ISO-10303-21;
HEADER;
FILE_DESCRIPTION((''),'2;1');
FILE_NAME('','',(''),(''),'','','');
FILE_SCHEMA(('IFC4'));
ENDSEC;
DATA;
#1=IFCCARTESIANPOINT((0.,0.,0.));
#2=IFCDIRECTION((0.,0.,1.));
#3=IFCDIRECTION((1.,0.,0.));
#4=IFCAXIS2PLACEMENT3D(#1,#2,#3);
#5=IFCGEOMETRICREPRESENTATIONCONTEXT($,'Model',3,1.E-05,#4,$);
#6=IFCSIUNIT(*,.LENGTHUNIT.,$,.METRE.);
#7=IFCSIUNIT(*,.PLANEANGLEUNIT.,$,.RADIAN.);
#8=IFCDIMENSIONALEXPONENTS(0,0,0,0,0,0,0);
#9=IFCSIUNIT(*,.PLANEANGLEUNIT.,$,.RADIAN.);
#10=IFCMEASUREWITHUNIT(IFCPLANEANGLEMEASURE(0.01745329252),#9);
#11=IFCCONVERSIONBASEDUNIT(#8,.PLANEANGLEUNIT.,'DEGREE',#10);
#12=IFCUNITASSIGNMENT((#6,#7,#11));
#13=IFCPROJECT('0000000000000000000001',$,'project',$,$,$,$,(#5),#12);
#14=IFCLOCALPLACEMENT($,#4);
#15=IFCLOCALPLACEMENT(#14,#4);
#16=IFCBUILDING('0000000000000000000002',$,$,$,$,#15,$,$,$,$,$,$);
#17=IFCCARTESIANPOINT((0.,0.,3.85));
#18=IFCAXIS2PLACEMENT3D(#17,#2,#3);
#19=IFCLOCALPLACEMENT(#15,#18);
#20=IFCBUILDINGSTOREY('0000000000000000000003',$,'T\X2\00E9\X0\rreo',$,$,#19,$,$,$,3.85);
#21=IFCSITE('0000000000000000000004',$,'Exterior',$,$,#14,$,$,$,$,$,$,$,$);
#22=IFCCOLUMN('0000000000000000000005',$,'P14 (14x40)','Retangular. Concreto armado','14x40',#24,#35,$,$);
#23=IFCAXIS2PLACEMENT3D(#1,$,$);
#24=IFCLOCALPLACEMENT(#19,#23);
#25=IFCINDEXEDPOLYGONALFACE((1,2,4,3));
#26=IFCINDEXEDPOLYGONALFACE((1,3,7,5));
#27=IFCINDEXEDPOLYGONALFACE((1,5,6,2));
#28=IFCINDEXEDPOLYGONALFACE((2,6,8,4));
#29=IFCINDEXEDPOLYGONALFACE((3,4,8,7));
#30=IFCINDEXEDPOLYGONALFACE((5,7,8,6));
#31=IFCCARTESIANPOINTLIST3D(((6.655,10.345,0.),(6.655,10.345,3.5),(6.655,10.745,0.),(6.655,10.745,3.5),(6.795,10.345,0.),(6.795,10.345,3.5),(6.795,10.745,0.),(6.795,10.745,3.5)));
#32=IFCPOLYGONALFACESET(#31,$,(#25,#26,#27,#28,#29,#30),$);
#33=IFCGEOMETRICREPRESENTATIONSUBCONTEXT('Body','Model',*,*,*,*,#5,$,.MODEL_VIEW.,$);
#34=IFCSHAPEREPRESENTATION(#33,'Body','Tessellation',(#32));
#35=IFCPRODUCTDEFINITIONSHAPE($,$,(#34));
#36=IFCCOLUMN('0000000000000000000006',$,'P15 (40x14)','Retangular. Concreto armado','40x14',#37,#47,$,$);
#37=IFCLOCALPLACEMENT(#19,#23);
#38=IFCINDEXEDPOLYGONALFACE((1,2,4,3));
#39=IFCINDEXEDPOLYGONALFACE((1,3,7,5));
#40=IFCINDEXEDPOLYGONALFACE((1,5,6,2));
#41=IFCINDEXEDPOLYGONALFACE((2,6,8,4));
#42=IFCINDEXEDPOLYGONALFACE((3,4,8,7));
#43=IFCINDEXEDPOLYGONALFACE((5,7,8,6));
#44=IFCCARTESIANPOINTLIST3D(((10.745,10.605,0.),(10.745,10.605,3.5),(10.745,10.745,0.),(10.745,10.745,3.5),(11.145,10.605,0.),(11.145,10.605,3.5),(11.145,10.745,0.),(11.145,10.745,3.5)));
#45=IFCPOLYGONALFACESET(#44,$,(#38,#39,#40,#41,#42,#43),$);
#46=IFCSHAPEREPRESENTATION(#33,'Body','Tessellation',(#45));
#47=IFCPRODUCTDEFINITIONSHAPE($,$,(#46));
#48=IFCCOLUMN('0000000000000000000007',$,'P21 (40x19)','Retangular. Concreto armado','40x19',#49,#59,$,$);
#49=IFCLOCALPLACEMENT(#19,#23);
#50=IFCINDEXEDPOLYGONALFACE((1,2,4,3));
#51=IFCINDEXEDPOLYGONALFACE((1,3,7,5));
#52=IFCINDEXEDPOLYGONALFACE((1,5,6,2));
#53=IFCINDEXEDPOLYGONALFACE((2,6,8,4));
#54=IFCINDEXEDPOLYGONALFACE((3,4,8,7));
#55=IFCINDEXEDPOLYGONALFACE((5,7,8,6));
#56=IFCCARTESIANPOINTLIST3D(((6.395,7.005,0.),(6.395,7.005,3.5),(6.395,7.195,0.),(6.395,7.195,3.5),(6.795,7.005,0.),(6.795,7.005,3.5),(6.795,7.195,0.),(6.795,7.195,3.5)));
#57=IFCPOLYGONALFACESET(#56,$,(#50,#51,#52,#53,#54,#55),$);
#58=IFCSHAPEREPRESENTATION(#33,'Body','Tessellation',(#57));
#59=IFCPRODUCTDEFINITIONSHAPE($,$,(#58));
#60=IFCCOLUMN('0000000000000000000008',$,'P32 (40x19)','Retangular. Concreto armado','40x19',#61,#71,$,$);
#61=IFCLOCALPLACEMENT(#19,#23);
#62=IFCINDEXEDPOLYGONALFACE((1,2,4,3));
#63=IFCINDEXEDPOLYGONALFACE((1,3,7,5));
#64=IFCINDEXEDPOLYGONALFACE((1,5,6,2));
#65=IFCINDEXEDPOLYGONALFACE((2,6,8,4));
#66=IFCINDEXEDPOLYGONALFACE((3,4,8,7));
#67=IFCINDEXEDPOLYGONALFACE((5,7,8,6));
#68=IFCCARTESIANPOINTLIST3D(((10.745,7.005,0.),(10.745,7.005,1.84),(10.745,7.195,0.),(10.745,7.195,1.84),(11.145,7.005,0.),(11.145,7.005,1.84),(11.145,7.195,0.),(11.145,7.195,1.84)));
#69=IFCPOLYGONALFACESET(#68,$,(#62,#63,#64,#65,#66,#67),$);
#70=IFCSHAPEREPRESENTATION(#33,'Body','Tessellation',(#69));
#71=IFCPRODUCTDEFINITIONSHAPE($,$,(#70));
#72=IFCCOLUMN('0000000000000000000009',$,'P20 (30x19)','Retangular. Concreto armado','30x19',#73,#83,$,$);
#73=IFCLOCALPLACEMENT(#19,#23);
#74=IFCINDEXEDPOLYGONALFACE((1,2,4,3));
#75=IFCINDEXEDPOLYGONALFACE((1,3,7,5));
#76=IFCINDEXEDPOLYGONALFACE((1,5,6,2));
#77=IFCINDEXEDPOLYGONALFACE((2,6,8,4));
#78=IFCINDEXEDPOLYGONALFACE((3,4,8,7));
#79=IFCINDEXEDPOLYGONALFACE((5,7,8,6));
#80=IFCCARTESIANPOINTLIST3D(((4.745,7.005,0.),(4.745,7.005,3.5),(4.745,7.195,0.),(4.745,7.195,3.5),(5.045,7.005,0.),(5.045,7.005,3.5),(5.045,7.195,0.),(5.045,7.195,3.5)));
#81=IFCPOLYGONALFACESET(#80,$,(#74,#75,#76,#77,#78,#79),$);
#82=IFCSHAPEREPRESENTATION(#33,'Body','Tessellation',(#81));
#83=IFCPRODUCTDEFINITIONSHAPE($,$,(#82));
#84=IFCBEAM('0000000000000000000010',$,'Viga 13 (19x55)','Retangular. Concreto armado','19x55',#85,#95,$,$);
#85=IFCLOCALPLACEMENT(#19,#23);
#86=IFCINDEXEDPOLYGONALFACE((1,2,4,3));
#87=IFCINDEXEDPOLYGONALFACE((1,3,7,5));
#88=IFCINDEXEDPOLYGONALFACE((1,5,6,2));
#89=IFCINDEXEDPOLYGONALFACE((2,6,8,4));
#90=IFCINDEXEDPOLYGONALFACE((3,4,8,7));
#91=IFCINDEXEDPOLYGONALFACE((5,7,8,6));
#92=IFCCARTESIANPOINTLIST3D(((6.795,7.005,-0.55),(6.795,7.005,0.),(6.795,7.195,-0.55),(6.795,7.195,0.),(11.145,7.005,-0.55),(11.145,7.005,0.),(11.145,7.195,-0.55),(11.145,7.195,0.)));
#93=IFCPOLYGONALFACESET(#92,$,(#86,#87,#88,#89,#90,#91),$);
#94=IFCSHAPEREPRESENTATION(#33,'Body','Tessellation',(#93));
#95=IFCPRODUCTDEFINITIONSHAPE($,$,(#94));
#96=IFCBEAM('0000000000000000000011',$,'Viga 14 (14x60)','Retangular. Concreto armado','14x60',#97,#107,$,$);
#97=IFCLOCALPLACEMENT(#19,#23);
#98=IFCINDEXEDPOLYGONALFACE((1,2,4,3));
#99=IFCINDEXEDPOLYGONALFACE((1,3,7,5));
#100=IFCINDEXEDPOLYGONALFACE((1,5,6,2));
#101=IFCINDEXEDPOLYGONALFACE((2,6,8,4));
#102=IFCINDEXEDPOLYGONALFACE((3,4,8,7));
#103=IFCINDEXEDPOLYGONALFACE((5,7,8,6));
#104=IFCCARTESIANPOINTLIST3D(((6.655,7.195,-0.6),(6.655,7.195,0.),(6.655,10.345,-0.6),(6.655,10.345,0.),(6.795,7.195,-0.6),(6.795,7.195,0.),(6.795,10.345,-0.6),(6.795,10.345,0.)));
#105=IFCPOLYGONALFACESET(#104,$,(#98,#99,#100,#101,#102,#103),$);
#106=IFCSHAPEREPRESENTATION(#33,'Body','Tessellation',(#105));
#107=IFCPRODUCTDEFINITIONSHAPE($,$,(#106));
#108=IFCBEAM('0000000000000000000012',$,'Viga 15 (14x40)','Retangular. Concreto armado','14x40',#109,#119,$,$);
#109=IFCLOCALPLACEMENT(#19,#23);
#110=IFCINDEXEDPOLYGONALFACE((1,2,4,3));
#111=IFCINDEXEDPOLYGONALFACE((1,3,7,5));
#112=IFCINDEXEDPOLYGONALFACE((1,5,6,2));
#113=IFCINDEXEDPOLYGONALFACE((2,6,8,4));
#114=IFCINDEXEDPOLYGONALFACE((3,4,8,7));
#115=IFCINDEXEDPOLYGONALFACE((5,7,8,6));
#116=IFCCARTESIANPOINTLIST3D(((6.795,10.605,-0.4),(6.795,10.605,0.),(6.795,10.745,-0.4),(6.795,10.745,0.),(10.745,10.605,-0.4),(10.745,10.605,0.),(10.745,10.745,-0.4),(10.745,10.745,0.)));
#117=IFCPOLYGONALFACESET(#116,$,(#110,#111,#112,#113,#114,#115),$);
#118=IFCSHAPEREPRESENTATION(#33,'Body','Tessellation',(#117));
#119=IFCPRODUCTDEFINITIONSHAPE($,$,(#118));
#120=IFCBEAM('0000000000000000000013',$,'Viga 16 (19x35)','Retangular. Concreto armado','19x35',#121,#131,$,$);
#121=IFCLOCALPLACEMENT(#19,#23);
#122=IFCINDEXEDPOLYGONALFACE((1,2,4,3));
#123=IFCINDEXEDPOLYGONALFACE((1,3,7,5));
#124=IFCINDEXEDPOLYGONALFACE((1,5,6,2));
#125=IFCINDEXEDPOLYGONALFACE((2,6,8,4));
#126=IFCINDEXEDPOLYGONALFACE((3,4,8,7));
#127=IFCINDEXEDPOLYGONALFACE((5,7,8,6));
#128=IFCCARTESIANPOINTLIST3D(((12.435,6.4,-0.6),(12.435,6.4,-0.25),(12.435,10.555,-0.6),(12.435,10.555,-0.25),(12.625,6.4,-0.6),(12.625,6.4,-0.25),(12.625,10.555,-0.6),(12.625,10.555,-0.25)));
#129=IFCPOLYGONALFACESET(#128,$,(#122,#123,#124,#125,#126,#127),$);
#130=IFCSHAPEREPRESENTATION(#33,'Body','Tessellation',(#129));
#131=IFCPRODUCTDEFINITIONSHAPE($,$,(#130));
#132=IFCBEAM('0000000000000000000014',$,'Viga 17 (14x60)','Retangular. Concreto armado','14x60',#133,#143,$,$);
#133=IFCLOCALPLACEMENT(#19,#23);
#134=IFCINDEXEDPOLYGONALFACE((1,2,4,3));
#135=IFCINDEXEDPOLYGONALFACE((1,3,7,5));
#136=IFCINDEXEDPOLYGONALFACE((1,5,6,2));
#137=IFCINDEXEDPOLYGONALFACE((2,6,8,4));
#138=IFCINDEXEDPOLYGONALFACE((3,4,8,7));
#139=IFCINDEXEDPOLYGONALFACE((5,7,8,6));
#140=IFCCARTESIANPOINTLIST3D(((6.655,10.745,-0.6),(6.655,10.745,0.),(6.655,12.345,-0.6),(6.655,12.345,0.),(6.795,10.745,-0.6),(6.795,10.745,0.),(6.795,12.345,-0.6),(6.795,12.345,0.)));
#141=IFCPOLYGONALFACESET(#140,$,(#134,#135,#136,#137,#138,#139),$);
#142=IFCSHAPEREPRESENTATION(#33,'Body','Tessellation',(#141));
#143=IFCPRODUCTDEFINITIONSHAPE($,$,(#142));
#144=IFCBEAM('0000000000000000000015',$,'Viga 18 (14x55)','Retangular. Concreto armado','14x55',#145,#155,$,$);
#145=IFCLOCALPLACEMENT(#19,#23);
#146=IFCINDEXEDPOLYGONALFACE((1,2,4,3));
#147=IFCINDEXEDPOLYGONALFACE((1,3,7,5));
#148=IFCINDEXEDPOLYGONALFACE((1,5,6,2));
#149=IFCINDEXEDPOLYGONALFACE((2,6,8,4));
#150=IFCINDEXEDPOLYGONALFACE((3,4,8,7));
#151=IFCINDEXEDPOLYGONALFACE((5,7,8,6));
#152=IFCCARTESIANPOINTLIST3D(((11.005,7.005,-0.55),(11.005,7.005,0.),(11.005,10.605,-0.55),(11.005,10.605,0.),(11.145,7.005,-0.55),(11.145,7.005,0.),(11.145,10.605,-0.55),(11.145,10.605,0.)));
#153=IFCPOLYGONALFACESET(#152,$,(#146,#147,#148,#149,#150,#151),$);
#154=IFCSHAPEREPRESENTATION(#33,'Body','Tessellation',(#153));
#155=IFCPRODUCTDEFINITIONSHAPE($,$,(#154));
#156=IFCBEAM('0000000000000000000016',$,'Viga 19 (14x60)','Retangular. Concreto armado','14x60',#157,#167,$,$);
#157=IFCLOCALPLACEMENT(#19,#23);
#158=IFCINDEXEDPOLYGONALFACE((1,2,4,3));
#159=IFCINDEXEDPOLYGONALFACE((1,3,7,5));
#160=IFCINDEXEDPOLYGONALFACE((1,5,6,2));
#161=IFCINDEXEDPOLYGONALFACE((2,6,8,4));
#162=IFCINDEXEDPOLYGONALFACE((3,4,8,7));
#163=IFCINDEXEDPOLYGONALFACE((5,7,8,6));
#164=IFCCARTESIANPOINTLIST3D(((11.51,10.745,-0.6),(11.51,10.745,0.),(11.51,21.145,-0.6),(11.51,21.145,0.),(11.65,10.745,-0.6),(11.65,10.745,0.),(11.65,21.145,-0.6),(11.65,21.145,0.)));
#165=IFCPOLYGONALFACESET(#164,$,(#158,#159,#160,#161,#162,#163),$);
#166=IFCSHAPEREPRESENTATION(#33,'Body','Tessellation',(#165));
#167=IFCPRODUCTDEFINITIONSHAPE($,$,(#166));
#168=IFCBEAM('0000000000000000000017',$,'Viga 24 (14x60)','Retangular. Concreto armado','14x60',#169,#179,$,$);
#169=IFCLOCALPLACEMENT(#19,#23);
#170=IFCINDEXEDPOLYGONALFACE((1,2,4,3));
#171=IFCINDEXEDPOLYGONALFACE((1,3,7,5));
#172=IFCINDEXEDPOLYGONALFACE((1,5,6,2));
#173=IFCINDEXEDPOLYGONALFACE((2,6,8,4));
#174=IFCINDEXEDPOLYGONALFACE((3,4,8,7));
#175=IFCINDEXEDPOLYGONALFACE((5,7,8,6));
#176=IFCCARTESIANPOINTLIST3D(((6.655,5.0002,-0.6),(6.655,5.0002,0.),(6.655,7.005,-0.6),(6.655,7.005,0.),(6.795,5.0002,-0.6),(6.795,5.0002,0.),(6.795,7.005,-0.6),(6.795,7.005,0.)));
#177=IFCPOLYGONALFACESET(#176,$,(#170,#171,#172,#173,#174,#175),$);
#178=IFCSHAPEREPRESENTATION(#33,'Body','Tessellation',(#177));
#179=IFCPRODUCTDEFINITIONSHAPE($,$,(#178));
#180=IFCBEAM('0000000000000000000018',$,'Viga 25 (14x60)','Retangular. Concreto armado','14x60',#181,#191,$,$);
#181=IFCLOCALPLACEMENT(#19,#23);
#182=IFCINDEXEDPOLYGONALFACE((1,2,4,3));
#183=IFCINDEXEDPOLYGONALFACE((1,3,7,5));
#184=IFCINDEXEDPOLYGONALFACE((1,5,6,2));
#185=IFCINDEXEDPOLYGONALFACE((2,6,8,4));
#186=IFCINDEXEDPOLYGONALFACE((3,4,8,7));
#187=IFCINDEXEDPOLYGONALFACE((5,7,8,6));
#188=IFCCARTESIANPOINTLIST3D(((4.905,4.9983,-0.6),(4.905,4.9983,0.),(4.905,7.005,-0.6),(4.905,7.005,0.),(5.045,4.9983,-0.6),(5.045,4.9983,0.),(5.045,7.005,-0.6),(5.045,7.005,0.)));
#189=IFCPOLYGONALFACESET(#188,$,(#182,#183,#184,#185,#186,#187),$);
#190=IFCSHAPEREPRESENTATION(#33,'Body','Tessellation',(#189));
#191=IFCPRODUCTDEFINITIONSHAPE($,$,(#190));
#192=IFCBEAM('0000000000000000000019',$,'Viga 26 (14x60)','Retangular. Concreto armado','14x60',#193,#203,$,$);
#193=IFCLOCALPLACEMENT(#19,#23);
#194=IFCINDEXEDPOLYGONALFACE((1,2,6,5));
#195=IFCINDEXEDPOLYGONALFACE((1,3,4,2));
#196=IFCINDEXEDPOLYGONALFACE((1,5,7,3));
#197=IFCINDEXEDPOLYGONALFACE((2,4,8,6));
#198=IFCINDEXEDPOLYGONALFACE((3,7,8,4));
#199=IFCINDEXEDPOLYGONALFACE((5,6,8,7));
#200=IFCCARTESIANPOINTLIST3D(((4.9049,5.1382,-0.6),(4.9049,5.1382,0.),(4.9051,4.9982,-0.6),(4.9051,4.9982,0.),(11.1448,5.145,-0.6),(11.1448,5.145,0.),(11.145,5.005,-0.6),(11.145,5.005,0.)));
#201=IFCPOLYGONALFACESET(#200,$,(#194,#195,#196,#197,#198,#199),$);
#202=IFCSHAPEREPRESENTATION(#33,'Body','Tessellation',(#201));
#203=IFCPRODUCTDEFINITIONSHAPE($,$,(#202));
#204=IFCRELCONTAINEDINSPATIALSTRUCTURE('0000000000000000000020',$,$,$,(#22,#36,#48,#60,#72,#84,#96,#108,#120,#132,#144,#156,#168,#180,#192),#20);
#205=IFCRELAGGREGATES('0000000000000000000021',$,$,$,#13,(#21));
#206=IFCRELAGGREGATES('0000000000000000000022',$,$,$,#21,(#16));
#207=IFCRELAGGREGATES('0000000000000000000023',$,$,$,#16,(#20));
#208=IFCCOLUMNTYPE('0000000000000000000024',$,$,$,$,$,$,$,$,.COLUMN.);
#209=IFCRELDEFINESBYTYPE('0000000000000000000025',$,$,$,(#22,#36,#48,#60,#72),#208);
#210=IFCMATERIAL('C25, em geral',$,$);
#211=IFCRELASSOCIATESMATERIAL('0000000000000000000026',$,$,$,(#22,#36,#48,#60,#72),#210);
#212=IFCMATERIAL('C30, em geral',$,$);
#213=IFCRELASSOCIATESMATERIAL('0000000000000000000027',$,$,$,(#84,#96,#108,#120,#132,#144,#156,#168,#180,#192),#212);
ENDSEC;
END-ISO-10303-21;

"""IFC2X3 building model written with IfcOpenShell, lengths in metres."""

from ifc_helpers import new_model, entity, si_unit, converted_unit, frame, frame_2d, origin_with_axes, place, context, subcontext, project, spatial, rectangle, extrude, material, type_object, element, save


model = new_model("IFC2X3")

# Units and contexts
model_context = context("Model", 3, precision=1e-05, world=origin_with_axes())
body_context = subcontext(model_context, "Body", "Model", "MODEL_VIEW")
ifc_project = project(units=[si_unit("LENGTHUNIT", "METRE"), si_unit("PLANEANGLEUNIT", "RADIAN"), converted_unit("PLANEANGLEUNIT", "DEGREE", entity("IfcPlaneAngleMeasure", 0.01745329252), si_unit("PLANEANGLEUNIT", "RADIAN"), dimensions=[0, 0, 0, 0, 0, 0, 0])], contexts=[model_context])

# Site, building, storey
site_placement = place(None, origin_with_axes())
site = spatial("IfcSite", under=ifc_project, at=site_placement, Name="Exterior")
building_placement = place(site_placement, origin_with_axes())
building = spatial("IfcBuilding", under=site, at=building_placement)
storey_placement = place(building_placement, frame((0.0, 0.0, 3.85), z_axis=(0.0, 0.0, 1.0), x_axis=(1.0, 0.0, 0.0)))
storey = spatial("IfcBuildingStorey", under=building, at=storey_placement, Name="Térreo", Elevation=3.85)

# Columns
ifc_material_1 = material(Name="C25, em geral")
column_type = type_object("IfcColumnType", PredefinedType="COLUMN")
column_1_placement = place(storey_placement, frame((6.655, 10.745, 0.0), z_axis=(0.0, 0.0, 1.0), x_axis=(1.0, 0.0, 0.0)))
element("IfcColumn", 1, at=column_1_placement, inside=storey, type_object=column_type, material=ifc_material_1, Name="P14 (14x40)", Description="Retangular. Concreto armado", ObjectType="14x40", context=body_context, shape_type="SweptSolid", body=[
    extrude(rectangle(XDim=0.14, YDim=0.4, at=frame_2d((0.07, -0.2), x_axis=(1.0, 0.0))), origin_with_axes(), (0.0, 0.0, 1.0), 3.5),
])
column_2_placement = place(storey_placement, frame((11.145, 10.605, 0.0), z_axis=(0.0, 0.0, 1.0), x_axis=(1.0, 0.0, 0.0)))
element("IfcColumn", 2, at=column_2_placement, inside=storey, type_object=column_type, material=ifc_material_1, Name="P15 (40x14)", Description="Retangular. Concreto armado", ObjectType="40x14", context=body_context, shape_type="SweptSolid", body=[
    extrude(rectangle(XDim=0.4, YDim=0.14, at=frame_2d((-0.2, 0.07), x_axis=(1.0, 0.0))), origin_with_axes(), (0.0, 0.0, 1.0), 3.5),
])
column_3_placement = place(storey_placement, frame((6.795, 7.005, 0.0), z_axis=(0.0, 0.0, 1.0), x_axis=(1.0, 0.0, 0.0)))
element("IfcColumn", 3, at=column_3_placement, inside=storey, type_object=column_type, material=ifc_material_1, Name="P21 (40x19)", Description="Retangular. Concreto armado", ObjectType="40x19", context=body_context, shape_type="SweptSolid", body=[
    extrude(rectangle(XDim=0.4, YDim=0.19, at=frame_2d((-0.2, 0.095), x_axis=(1.0, 0.0))), origin_with_axes(), (0.0, 0.0, 1.0), 3.5),
])
column_4_placement = place(storey_placement, frame((11.145, 7.005, 0.0), z_axis=(0.0, 0.0, 1.0), x_axis=(1.0, 0.0, 0.0)))
element("IfcColumn", 4, at=column_4_placement, inside=storey, type_object=column_type, material=ifc_material_1, Name="P32 (40x19)", Description="Retangular. Concreto armado", ObjectType="40x19", context=body_context, shape_type="SweptSolid", body=[
    extrude(rectangle(XDim=0.4, YDim=0.19, at=frame_2d((-0.2, 0.095), x_axis=(1.0, 0.0))), origin_with_axes(), (0.0, 0.0, 1.0), 1.84),
])
column_5_placement = place(storey_placement, frame((5.045, 7.005, 0.0), z_axis=(0.0, 0.0, 1.0), x_axis=(1.0, 0.0, 0.0)))
element("IfcColumn", 5, at=column_5_placement, inside=storey, type_object=column_type, material=ifc_material_1, Name="P20 (30x19)", Description="Retangular. Concreto armado", ObjectType="30x19", context=body_context, shape_type="SweptSolid", body=[
    extrude(rectangle(XDim=0.3, YDim=0.19, at=frame_2d((-0.15, 0.095), x_axis=(1.0, 0.0))), origin_with_axes(), (0.0, 0.0, 1.0), 3.5),
])

# Beams
ifc_material_2 = material(Name="C30, em geral")
beam_1_placement = place(storey_placement, frame((6.795, 7.1, 0.0), z_axis=(1.0, 0.0, 0.0), x_axis=(0.0, 1.0, 0.0)))
element("IfcBeam", 6, at=beam_1_placement, inside=storey, material=ifc_material_2, Name="Viga 13 (19x55)", Description="Retangular. Concreto armado", ObjectType="19x55", context=body_context, shape_type="SweptSolid", body=[
    extrude(rectangle(XDim=0.19, YDim=0.55, at=frame_2d((0.0, -0.275), x_axis=(1.0, 0.0))), origin_with_axes(), (0.0, 0.0, 1.0), 4.35),
])
beam_2_placement = place(storey_placement, frame((6.725, 10.345, 0.0), z_axis=(0.0, -1.0, 0.0), x_axis=(1.0, 0.0, 0.0)))
element("IfcBeam", 7, at=beam_2_placement, inside=storey, material=ifc_material_2, Name="Viga 14 (14x60)", Description="Retangular. Concreto armado", ObjectType="14x60", context=body_context, shape_type="SweptSolid", body=[
    extrude(rectangle(XDim=0.14, YDim=0.6, at=frame_2d((0.0, -0.3), x_axis=(1.0, 0.0))), origin_with_axes(), (0.0, 0.0, 1.0), 3.15),
])
beam_3_placement = place(storey_placement, frame((6.795, 10.675, 0.0), z_axis=(1.0, 0.0, 0.0), x_axis=(0.0, 1.0, 0.0)))
element("IfcBeam", 8, at=beam_3_placement, inside=storey, material=ifc_material_2, Name="Viga 15 (14x40)", Description="Retangular. Concreto armado", ObjectType="14x40", context=body_context, shape_type="SweptSolid", body=[
    extrude(rectangle(XDim=0.14, YDim=0.4, at=frame_2d((0.0, -0.2), x_axis=(1.0, 0.0))), origin_with_axes(), (0.0, 0.0, 1.0), 3.95),
])
beam_4_placement = place(storey_placement, frame((12.53, 6.4, -0.25), z_axis=(0.0, 1.0, 0.0), x_axis=(-1.0, 0.0, 0.0)))
element("IfcBeam", 9, at=beam_4_placement, inside=storey, material=ifc_material_2, Name="Viga 16 (19x35)", Description="Retangular. Concreto armado", ObjectType="19x35", context=body_context, shape_type="SweptSolid", body=[
    extrude(rectangle(XDim=0.19, YDim=0.35, at=frame_2d((0.0, -0.175), x_axis=(1.0, 0.0))), origin_with_axes(), (0.0, 0.0, 1.0), 4.155),
])
beam_5_placement = place(storey_placement, frame((6.725, 10.745, 0.0), z_axis=(0.0, 1.0, 0.0), x_axis=(-1.0, 0.0, 0.0)))
element("IfcBeam", 10, at=beam_5_placement, inside=storey, material=ifc_material_2, Name="Viga 17 (14x60)", Description="Retangular. Concreto armado", ObjectType="14x60", context=body_context, shape_type="SweptSolid", body=[
    extrude(rectangle(XDim=0.14, YDim=0.6, at=frame_2d((0.0, -0.3), x_axis=(1.0, 0.0))), origin_with_axes(), (0.0, 0.0, 1.0), 1.6),
])
beam_6_placement = place(storey_placement, frame((11.075, 7.005, 0.0), z_axis=(0.0, 1.0, 0.0), x_axis=(-1.0, 0.0, 0.0)))
element("IfcBeam", 11, at=beam_6_placement, inside=storey, material=ifc_material_2, Name="Viga 18 (14x55)", Description="Retangular. Concreto armado", ObjectType="14x55", context=body_context, shape_type="SweptSolid", body=[
    extrude(rectangle(XDim=0.14, YDim=0.55, at=frame_2d((0.0, -0.275), x_axis=(1.0, 0.0))), origin_with_axes(), (0.0, 0.0, 1.0), 3.6),
])
beam_7_placement = place(storey_placement, frame((11.58, 10.745, 0.0), z_axis=(0.0, 1.0, 0.0), x_axis=(-1.0, 0.0, 0.0)))
element("IfcBeam", 12, at=beam_7_placement, inside=storey, material=ifc_material_2, Name="Viga 19 (14x60)", Description="Retangular. Concreto armado", ObjectType="14x60", context=body_context, shape_type="SweptSolid", body=[
    extrude(rectangle(XDim=0.14, YDim=0.6, at=frame_2d((0.0, -0.3), x_axis=(1.0, 0.0))), origin_with_axes(), (0.0, 0.0, 1.0), 10.4),
])
beam_8_placement = place(storey_placement, frame((6.725, 5.0002, 0.0), z_axis=(0.0, 1.0, 0.0), x_axis=(-1.0, 0.0, 0.0)))
element("IfcBeam", 13, at=beam_8_placement, inside=storey, material=ifc_material_2, Name="Viga 24 (14x60)", Description="Retangular. Concreto armado", ObjectType="14x60", context=body_context, shape_type="SweptSolid", body=[
    extrude(rectangle(XDim=0.14, YDim=0.6, at=frame_2d((0.0, -0.3), x_axis=(1.0, 0.0))), origin_with_axes(), (0.0, 0.0, 1.0), 2.0048),
])
beam_9_placement = place(storey_placement, frame((4.975, 4.9983, 0.0), z_axis=(0.0, 1.0, 0.0), x_axis=(-1.0, 0.0, 0.0)))
element("IfcBeam", 14, at=beam_9_placement, inside=storey, material=ifc_material_2, Name="Viga 25 (14x60)", Description="Retangular. Concreto armado", ObjectType="14x60", context=body_context, shape_type="SweptSolid", body=[
    extrude(rectangle(XDim=0.14, YDim=0.6, at=frame_2d((0.0, -0.3), x_axis=(1.0, 0.0))), origin_with_axes(), (0.0, 0.0, 1.0), 2.0067),
])
beam_10_placement = place(storey_placement, frame((4.905, 5.0682, 0.0), z_axis=(0.999999, 0.001095, 0.0), x_axis=(-0.001095, 0.999999, 0.0)))
element("IfcBeam", 15, at=beam_10_placement, inside=storey, material=ifc_material_2, Name="Viga 26 (14x60)", Description="Retangular. Concreto armado", ObjectType="14x60", context=body_context, shape_type="SweptSolid", body=[
    extrude(rectangle(XDim=0.14, YDim=0.6, at=frame_2d((0.0, -0.3), x_axis=(1.0, 0.0))), origin_with_axes(), (0.0, 0.0, 1.0), 6.2399),
])

save(model, "model.ifc")
